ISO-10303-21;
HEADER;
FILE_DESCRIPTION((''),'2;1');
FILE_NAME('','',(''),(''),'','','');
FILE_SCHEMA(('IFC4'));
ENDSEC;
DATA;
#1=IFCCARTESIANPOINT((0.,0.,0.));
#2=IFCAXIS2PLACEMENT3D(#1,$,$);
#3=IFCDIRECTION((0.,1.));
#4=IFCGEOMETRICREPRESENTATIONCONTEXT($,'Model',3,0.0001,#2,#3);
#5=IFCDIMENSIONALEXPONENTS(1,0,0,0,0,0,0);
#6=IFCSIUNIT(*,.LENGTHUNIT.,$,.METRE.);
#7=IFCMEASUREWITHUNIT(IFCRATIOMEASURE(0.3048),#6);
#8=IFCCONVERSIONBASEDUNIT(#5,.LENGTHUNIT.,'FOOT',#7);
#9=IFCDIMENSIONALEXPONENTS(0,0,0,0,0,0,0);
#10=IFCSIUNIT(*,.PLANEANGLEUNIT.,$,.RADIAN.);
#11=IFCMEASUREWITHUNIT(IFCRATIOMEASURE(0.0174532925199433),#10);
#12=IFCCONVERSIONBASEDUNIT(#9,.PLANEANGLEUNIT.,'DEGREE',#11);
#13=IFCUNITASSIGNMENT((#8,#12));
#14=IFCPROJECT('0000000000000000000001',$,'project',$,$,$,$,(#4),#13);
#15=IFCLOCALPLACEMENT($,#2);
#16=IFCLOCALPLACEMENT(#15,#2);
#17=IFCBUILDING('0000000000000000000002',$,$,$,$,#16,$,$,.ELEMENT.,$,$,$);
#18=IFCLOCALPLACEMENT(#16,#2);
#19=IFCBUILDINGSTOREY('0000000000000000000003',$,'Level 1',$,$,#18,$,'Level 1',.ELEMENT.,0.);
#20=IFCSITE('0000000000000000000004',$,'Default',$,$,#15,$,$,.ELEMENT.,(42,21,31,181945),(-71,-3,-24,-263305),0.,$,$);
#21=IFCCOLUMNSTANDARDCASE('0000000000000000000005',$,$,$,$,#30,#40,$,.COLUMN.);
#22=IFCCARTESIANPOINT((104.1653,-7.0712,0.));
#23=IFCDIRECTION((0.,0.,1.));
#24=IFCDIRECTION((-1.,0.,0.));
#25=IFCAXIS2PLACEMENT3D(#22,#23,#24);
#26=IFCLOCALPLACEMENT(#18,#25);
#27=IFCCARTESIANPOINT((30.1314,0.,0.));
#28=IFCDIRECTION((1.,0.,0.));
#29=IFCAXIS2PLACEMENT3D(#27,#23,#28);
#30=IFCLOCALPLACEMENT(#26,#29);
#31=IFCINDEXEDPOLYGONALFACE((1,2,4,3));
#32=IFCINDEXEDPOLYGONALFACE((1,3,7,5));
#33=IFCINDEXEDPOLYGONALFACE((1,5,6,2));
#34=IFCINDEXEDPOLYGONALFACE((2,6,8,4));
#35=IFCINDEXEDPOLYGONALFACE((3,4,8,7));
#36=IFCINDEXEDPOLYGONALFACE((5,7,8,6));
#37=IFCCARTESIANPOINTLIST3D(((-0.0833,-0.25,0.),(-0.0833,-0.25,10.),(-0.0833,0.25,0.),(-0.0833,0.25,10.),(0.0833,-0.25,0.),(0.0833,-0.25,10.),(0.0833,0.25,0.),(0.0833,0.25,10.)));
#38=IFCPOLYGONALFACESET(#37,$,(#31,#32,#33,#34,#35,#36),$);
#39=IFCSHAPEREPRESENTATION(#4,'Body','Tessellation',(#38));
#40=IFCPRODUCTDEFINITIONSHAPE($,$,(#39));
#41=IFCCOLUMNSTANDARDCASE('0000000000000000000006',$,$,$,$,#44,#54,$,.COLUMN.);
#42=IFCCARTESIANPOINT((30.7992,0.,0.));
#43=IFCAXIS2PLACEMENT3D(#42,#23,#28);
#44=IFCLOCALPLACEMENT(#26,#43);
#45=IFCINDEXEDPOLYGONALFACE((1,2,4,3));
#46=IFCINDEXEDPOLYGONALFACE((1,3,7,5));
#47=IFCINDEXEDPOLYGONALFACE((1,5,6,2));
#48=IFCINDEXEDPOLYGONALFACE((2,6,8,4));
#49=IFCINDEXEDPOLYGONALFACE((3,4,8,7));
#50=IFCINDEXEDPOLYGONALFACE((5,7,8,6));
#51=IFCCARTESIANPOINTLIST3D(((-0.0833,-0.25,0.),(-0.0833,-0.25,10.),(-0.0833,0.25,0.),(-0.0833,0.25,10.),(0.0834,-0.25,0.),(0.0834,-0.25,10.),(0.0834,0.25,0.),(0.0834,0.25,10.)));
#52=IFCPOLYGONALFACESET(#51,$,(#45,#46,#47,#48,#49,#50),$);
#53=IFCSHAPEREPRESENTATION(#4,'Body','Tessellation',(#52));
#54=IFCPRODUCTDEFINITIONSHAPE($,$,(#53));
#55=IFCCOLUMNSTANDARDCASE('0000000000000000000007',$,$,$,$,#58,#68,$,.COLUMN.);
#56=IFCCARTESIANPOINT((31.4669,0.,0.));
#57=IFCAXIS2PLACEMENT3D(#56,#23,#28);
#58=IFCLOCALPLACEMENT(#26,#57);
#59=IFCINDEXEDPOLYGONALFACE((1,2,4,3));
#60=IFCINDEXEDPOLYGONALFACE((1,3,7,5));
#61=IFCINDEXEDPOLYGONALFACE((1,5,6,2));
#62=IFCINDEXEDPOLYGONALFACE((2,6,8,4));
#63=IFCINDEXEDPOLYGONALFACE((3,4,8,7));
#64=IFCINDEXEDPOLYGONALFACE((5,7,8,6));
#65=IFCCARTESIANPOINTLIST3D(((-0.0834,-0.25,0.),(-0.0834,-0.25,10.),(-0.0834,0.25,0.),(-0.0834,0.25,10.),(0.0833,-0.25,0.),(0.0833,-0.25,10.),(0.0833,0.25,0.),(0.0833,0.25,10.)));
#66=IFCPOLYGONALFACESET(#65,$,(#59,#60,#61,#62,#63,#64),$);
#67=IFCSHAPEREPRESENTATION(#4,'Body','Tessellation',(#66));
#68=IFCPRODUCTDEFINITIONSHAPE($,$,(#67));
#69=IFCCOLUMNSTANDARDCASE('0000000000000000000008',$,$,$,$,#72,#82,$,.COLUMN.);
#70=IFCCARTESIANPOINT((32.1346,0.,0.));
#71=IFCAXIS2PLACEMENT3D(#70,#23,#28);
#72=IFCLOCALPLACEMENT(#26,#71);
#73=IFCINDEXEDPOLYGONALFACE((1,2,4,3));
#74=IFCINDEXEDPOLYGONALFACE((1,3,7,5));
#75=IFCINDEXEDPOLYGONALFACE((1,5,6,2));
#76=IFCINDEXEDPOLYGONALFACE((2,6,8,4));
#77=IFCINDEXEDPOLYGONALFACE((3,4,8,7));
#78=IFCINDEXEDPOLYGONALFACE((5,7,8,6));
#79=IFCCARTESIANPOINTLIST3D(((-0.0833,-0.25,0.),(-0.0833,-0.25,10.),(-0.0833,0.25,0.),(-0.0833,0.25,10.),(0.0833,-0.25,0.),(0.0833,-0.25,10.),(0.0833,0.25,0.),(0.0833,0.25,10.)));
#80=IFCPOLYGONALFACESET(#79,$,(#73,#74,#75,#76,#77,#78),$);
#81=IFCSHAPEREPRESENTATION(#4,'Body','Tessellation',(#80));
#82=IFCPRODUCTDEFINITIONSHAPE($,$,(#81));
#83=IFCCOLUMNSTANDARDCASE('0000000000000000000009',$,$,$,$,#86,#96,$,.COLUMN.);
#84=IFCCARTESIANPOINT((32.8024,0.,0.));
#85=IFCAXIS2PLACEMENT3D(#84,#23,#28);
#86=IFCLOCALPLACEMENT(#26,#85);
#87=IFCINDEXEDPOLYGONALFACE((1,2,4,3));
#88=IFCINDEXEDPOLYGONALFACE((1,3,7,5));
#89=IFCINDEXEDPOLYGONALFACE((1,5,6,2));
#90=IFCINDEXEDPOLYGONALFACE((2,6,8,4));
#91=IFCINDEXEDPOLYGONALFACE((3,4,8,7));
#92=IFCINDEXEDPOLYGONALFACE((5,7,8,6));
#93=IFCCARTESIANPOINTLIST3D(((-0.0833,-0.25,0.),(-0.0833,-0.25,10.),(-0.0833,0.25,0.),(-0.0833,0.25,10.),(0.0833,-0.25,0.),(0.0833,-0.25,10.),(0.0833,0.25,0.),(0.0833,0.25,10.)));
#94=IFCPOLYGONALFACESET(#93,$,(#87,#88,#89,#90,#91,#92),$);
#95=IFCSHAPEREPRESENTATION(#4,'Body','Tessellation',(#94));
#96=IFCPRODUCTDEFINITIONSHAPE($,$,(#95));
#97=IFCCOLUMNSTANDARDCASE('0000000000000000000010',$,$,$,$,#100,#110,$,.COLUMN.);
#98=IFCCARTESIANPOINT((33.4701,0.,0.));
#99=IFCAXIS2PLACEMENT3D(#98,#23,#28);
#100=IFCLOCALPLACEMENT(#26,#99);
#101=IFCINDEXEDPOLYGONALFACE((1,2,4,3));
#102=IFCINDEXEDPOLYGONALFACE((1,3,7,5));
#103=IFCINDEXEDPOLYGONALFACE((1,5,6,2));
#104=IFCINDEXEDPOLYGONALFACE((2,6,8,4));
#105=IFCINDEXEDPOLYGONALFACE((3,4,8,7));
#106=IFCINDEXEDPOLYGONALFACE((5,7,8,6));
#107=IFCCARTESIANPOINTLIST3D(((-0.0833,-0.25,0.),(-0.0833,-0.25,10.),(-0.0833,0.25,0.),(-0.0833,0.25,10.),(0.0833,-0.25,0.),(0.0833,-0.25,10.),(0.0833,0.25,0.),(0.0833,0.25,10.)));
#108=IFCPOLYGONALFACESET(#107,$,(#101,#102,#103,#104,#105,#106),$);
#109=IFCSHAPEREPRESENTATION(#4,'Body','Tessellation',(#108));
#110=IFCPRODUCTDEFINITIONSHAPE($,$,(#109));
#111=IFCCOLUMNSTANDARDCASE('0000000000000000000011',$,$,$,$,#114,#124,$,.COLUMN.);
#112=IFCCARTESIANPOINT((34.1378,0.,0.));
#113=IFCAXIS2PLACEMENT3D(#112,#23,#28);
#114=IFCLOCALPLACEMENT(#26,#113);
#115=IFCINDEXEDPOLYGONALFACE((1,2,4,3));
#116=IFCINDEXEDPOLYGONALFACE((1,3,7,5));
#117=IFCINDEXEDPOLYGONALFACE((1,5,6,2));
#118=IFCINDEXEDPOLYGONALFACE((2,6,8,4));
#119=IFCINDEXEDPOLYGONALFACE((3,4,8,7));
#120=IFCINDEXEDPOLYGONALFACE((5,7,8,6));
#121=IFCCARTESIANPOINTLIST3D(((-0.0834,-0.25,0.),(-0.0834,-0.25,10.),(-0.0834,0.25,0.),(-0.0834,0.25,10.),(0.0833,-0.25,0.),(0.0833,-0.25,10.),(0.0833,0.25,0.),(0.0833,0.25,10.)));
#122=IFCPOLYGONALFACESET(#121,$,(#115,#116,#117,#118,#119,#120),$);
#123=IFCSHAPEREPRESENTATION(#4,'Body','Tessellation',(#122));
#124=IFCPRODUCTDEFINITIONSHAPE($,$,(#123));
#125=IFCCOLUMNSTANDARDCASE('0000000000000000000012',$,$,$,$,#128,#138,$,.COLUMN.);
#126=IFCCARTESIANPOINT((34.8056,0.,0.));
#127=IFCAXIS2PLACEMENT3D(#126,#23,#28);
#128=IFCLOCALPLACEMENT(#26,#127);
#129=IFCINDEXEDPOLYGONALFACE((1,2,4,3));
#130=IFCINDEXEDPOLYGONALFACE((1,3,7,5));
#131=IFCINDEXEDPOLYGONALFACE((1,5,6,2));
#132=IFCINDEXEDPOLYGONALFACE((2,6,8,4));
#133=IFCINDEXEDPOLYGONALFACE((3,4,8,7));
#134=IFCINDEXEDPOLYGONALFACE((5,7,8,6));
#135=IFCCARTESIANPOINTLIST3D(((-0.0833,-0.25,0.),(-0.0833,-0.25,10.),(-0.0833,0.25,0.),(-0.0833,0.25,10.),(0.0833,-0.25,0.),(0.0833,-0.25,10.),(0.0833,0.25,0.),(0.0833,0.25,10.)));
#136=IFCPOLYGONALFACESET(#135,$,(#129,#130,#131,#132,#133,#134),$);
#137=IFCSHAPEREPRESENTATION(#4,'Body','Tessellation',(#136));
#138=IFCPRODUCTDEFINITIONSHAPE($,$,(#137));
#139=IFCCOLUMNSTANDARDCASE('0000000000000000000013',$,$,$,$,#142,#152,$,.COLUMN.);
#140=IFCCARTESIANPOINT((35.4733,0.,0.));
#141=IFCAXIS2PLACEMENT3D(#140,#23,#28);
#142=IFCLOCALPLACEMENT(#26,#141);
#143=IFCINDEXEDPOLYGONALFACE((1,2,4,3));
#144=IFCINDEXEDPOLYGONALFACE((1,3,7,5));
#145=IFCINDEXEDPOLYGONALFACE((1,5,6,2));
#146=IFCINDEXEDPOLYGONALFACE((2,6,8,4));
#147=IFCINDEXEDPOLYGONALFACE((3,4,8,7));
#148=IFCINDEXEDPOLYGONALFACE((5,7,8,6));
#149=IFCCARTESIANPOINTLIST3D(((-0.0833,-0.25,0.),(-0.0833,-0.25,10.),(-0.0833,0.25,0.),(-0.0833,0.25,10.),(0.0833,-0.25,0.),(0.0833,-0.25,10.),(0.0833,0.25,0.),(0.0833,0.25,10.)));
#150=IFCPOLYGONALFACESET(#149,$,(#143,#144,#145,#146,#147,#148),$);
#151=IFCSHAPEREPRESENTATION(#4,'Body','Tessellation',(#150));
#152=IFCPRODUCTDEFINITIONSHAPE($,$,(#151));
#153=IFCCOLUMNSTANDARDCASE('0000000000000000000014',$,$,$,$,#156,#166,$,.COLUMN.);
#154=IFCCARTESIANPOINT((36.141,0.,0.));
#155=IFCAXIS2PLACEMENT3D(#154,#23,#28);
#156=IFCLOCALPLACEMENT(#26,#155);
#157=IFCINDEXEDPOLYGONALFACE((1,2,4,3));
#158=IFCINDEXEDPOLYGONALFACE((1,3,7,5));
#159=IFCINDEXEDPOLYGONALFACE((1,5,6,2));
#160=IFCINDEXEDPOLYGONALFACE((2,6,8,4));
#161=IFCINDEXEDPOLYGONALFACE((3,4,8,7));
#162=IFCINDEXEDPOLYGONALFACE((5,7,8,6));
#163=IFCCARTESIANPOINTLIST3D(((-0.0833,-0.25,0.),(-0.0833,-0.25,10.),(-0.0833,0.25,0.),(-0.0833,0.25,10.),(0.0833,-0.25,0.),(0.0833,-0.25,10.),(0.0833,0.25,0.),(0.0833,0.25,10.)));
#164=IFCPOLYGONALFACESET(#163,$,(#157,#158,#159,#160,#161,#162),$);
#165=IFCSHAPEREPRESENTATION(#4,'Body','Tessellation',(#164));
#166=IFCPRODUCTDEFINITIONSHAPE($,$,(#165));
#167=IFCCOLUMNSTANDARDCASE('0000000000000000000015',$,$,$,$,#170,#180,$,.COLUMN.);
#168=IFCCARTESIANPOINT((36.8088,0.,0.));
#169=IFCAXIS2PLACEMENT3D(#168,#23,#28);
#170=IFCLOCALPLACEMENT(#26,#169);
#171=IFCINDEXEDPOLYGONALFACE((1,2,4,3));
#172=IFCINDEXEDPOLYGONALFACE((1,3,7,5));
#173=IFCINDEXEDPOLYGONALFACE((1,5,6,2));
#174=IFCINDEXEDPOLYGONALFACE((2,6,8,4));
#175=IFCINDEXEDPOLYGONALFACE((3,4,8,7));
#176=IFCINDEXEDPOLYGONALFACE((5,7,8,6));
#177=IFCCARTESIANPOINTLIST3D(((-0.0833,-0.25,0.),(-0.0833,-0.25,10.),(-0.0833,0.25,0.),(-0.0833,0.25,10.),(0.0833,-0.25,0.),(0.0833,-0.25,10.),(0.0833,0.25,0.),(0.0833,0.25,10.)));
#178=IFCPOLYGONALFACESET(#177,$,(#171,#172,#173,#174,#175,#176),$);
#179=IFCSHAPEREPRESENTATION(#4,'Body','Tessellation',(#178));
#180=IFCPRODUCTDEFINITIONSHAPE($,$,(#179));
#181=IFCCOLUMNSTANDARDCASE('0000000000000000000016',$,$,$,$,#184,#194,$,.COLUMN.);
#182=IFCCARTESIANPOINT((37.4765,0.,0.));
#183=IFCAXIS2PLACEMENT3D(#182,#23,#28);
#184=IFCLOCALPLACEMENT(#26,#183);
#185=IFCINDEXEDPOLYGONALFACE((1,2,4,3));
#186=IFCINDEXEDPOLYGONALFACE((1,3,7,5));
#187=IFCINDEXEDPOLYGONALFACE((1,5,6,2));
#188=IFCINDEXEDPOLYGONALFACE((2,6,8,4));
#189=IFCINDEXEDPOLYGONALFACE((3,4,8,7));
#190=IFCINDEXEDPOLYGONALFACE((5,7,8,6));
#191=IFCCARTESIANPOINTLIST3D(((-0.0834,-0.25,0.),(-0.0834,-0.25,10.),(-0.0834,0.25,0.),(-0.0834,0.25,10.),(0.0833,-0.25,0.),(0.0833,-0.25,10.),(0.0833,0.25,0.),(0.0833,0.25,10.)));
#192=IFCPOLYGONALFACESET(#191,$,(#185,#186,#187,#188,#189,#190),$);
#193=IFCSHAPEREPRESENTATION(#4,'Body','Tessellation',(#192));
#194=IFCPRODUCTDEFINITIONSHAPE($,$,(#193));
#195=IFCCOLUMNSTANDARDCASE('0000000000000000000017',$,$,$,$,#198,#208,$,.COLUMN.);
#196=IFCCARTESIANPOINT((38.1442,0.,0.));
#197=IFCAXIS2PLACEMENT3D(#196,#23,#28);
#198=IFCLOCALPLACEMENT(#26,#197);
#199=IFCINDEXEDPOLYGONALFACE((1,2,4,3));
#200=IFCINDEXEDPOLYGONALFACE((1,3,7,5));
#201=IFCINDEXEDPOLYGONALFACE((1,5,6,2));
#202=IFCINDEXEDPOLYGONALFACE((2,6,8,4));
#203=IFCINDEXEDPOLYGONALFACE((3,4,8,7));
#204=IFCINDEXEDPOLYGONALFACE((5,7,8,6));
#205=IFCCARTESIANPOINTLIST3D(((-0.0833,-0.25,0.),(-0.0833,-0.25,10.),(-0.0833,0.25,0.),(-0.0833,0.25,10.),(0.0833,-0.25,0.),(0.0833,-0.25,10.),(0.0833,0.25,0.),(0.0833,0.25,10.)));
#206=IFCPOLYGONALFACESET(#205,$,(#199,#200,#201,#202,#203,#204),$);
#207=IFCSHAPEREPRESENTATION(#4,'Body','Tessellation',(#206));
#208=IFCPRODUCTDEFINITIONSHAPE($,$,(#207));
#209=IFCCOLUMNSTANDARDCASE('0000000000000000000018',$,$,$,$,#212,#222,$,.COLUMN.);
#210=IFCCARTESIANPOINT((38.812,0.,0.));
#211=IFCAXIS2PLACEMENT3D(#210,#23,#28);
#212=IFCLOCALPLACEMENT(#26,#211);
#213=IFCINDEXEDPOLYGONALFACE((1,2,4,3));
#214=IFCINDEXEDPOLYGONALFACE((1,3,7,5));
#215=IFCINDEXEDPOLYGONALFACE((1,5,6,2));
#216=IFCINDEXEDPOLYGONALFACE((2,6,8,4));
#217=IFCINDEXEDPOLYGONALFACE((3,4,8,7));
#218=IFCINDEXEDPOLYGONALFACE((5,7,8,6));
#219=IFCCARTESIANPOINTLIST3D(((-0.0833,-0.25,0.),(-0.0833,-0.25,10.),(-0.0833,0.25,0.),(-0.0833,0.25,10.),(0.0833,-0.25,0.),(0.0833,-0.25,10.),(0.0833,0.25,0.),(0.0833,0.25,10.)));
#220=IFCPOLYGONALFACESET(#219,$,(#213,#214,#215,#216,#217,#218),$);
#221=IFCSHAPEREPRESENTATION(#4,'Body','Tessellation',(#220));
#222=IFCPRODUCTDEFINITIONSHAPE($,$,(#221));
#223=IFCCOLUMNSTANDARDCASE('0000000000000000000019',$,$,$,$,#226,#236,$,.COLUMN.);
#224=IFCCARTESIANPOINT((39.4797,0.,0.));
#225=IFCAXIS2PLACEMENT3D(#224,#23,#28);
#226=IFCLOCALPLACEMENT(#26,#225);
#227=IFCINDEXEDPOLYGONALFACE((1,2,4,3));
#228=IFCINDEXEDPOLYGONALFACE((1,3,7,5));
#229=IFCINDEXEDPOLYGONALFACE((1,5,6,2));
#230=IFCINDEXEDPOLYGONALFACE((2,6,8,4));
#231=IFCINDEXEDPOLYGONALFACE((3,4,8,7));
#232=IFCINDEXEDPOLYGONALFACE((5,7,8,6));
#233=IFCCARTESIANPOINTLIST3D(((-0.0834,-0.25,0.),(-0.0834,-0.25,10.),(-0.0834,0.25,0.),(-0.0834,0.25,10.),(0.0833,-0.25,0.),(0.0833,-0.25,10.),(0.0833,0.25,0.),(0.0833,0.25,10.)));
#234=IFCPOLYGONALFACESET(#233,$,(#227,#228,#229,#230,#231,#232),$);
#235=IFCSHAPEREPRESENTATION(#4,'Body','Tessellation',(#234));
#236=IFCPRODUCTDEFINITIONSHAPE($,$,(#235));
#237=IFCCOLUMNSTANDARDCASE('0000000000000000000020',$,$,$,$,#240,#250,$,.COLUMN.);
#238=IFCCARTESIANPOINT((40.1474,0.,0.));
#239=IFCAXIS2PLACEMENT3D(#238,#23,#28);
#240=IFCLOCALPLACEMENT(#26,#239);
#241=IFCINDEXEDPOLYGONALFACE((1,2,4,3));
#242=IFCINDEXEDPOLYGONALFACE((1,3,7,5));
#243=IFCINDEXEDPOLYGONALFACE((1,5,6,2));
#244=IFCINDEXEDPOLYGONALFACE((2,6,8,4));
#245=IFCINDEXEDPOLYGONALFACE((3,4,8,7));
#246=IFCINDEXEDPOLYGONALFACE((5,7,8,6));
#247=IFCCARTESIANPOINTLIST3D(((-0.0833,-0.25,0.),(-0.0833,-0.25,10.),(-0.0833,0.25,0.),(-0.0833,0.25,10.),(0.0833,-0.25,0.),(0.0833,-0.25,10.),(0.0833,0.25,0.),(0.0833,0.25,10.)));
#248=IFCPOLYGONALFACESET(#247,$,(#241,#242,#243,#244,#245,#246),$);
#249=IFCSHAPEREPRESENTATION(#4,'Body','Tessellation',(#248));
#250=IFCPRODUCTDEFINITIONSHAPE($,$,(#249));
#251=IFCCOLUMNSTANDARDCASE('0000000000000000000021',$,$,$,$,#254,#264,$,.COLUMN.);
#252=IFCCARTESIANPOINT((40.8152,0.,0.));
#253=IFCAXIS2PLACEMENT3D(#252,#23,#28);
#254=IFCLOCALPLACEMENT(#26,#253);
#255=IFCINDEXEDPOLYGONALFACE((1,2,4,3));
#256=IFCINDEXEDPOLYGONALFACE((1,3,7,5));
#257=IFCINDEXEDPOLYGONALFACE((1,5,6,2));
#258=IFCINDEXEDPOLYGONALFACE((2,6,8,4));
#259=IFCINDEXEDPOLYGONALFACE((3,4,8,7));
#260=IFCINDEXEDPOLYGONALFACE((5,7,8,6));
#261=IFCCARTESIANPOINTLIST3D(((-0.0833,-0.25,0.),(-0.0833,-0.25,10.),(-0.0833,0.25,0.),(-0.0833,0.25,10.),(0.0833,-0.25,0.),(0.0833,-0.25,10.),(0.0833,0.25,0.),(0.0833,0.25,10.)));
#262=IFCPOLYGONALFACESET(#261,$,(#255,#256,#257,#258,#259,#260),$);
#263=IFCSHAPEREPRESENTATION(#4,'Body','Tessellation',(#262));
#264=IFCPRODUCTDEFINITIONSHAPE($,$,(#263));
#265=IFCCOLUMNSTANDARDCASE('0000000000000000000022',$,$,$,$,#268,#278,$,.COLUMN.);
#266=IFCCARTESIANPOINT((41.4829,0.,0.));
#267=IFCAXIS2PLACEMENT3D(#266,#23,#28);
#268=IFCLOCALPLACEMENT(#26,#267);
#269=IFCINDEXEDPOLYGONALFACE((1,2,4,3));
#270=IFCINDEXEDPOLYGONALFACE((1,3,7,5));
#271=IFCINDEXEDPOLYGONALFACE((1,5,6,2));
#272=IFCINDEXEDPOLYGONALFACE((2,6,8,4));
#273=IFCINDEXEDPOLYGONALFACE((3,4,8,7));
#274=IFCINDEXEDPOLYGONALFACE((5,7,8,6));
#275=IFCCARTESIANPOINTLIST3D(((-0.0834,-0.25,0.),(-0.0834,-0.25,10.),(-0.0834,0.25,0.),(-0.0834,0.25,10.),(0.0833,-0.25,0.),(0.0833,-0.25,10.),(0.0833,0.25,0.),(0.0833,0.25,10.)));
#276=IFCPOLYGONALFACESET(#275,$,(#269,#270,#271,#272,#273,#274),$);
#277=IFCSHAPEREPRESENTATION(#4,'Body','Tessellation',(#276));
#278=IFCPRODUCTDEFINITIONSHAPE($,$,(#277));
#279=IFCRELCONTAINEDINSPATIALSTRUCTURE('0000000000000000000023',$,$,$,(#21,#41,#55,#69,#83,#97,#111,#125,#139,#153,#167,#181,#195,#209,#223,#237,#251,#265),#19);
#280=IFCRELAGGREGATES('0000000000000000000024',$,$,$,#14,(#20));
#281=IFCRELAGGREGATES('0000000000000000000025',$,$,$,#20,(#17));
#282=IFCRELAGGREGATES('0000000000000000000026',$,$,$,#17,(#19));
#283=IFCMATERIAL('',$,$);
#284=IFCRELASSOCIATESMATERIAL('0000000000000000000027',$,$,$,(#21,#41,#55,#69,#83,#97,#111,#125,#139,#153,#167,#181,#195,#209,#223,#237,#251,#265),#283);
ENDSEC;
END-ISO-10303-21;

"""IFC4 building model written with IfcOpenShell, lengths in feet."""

from ifc_helpers import new_model, entity, si_unit, converted_unit, direction, frame, origin, place, context, project, spatial, rectangle, extrude, material, element, save


model = new_model("IFC4")

# Units and contexts
model_context = context("Model", 3, precision=0.0001, world=origin(), true_north=direction((0.0, 1.0)))
ifc_project = project(units=[converted_unit("LENGTHUNIT", "FOOT", entity("IfcRatioMeasure", 0.3048), si_unit("LENGTHUNIT", "METRE"), dimensions=[1, 0, 0, 0, 0, 0, 0]), converted_unit("PLANEANGLEUNIT", "DEGREE", entity("IfcRatioMeasure", 0.0174532925199433), si_unit("PLANEANGLEUNIT", "RADIAN"), dimensions=[0, 0, 0, 0, 0, 0, 0])], contexts=[model_context])

# Site, building, storey
site_placement = place(None, origin())
site = spatial("IfcSite", under=ifc_project, at=site_placement, Name="Default", CompositionType="ELEMENT", RefLatitude=(42, 21, 31, 181945), RefLongitude=(-71, -3, -24, -263305), RefElevation=0.0)
building_placement = place(site_placement, origin())
building = spatial("IfcBuilding", under=site, at=building_placement, CompositionType="ELEMENT")
storey_placement = place(building_placement, origin())
storey = spatial("IfcBuildingStorey", under=building, at=storey_placement, Name="Level 1", LongName="Level 1", CompositionType="ELEMENT", Elevation=0.0)

# Columns
ifc_material = material(Name="")
placement = place(storey_placement, frame((104.1653, -7.0712, 0.0), z_axis=(0.0, 0.0, 1.0), x_axis=(-1.0, 0.0, 0.0)))
for number, where, z_axis, x_axis in (
    (1, (30.1314, 0.0, 0.0), (0.0, 0.0, 1.0), (1.0, 0.0, 0.0)),
    (2, (30.7992, 0.0, 0.0), (0.0, 0.0, 1.0), (1.0, 0.0, 0.0)),
    (3, (31.4669, 0.0, 0.0), (0.0, 0.0, 1.0), (1.0, 0.0, 0.0)),
    (4, (32.1346, 0.0, 0.0), (0.0, 0.0, 1.0), (1.0, 0.0, 0.0)),
    (5, (32.8024, 0.0, 0.0), (0.0, 0.0, 1.0), (1.0, 0.0, 0.0)),
    (6, (33.4701, 0.0, 0.0), (0.0, 0.0, 1.0), (1.0, 0.0, 0.0)),
    (7, (34.1378, 0.0, 0.0), (0.0, 0.0, 1.0), (1.0, 0.0, 0.0)),
    (8, (34.8056, 0.0, 0.0), (0.0, 0.0, 1.0), (1.0, 0.0, 0.0)),
    (9, (35.4733, 0.0, 0.0), (0.0, 0.0, 1.0), (1.0, 0.0, 0.0)),
    (10, (36.141, 0.0, 0.0), (0.0, 0.0, 1.0), (1.0, 0.0, 0.0)),
    (11, (36.8088, 0.0, 0.0), (0.0, 0.0, 1.0), (1.0, 0.0, 0.0)),
    (12, (37.4765, 0.0, 0.0), (0.0, 0.0, 1.0), (1.0, 0.0, 0.0)),
    (13, (38.1442, 0.0, 0.0), (0.0, 0.0, 1.0), (1.0, 0.0, 0.0)),
    (14, (38.812, 0.0, 0.0), (0.0, 0.0, 1.0), (1.0, 0.0, 0.0)),
    (15, (39.4797, 0.0, 0.0), (0.0, 0.0, 1.0), (1.0, 0.0, 0.0)),
    (16, (40.1474, 0.0, 0.0), (0.0, 0.0, 1.0), (1.0, 0.0, 0.0)),
    (17, (40.8152, 0.0, 0.0), (0.0, 0.0, 1.0), (1.0, 0.0, 0.0)),
    (18, (41.4829, 0.0, 0.0), (0.0, 0.0, 1.0), (1.0, 0.0, 0.0)),
):
    element("IfcColumnStandardCase", number, at=place(placement, frame(where, z_axis=z_axis, x_axis=x_axis)), inside=storey, material=ifc_material, PredefinedType="COLUMN", context=model_context, shape_type="SweptSolid", body=[
        extrude(rectangle(XDim=0.1667, YDim=0.5), origin(), (0.0, 0.0, 1.0), 10.0),
    ])

save(model, "model.ifc")
